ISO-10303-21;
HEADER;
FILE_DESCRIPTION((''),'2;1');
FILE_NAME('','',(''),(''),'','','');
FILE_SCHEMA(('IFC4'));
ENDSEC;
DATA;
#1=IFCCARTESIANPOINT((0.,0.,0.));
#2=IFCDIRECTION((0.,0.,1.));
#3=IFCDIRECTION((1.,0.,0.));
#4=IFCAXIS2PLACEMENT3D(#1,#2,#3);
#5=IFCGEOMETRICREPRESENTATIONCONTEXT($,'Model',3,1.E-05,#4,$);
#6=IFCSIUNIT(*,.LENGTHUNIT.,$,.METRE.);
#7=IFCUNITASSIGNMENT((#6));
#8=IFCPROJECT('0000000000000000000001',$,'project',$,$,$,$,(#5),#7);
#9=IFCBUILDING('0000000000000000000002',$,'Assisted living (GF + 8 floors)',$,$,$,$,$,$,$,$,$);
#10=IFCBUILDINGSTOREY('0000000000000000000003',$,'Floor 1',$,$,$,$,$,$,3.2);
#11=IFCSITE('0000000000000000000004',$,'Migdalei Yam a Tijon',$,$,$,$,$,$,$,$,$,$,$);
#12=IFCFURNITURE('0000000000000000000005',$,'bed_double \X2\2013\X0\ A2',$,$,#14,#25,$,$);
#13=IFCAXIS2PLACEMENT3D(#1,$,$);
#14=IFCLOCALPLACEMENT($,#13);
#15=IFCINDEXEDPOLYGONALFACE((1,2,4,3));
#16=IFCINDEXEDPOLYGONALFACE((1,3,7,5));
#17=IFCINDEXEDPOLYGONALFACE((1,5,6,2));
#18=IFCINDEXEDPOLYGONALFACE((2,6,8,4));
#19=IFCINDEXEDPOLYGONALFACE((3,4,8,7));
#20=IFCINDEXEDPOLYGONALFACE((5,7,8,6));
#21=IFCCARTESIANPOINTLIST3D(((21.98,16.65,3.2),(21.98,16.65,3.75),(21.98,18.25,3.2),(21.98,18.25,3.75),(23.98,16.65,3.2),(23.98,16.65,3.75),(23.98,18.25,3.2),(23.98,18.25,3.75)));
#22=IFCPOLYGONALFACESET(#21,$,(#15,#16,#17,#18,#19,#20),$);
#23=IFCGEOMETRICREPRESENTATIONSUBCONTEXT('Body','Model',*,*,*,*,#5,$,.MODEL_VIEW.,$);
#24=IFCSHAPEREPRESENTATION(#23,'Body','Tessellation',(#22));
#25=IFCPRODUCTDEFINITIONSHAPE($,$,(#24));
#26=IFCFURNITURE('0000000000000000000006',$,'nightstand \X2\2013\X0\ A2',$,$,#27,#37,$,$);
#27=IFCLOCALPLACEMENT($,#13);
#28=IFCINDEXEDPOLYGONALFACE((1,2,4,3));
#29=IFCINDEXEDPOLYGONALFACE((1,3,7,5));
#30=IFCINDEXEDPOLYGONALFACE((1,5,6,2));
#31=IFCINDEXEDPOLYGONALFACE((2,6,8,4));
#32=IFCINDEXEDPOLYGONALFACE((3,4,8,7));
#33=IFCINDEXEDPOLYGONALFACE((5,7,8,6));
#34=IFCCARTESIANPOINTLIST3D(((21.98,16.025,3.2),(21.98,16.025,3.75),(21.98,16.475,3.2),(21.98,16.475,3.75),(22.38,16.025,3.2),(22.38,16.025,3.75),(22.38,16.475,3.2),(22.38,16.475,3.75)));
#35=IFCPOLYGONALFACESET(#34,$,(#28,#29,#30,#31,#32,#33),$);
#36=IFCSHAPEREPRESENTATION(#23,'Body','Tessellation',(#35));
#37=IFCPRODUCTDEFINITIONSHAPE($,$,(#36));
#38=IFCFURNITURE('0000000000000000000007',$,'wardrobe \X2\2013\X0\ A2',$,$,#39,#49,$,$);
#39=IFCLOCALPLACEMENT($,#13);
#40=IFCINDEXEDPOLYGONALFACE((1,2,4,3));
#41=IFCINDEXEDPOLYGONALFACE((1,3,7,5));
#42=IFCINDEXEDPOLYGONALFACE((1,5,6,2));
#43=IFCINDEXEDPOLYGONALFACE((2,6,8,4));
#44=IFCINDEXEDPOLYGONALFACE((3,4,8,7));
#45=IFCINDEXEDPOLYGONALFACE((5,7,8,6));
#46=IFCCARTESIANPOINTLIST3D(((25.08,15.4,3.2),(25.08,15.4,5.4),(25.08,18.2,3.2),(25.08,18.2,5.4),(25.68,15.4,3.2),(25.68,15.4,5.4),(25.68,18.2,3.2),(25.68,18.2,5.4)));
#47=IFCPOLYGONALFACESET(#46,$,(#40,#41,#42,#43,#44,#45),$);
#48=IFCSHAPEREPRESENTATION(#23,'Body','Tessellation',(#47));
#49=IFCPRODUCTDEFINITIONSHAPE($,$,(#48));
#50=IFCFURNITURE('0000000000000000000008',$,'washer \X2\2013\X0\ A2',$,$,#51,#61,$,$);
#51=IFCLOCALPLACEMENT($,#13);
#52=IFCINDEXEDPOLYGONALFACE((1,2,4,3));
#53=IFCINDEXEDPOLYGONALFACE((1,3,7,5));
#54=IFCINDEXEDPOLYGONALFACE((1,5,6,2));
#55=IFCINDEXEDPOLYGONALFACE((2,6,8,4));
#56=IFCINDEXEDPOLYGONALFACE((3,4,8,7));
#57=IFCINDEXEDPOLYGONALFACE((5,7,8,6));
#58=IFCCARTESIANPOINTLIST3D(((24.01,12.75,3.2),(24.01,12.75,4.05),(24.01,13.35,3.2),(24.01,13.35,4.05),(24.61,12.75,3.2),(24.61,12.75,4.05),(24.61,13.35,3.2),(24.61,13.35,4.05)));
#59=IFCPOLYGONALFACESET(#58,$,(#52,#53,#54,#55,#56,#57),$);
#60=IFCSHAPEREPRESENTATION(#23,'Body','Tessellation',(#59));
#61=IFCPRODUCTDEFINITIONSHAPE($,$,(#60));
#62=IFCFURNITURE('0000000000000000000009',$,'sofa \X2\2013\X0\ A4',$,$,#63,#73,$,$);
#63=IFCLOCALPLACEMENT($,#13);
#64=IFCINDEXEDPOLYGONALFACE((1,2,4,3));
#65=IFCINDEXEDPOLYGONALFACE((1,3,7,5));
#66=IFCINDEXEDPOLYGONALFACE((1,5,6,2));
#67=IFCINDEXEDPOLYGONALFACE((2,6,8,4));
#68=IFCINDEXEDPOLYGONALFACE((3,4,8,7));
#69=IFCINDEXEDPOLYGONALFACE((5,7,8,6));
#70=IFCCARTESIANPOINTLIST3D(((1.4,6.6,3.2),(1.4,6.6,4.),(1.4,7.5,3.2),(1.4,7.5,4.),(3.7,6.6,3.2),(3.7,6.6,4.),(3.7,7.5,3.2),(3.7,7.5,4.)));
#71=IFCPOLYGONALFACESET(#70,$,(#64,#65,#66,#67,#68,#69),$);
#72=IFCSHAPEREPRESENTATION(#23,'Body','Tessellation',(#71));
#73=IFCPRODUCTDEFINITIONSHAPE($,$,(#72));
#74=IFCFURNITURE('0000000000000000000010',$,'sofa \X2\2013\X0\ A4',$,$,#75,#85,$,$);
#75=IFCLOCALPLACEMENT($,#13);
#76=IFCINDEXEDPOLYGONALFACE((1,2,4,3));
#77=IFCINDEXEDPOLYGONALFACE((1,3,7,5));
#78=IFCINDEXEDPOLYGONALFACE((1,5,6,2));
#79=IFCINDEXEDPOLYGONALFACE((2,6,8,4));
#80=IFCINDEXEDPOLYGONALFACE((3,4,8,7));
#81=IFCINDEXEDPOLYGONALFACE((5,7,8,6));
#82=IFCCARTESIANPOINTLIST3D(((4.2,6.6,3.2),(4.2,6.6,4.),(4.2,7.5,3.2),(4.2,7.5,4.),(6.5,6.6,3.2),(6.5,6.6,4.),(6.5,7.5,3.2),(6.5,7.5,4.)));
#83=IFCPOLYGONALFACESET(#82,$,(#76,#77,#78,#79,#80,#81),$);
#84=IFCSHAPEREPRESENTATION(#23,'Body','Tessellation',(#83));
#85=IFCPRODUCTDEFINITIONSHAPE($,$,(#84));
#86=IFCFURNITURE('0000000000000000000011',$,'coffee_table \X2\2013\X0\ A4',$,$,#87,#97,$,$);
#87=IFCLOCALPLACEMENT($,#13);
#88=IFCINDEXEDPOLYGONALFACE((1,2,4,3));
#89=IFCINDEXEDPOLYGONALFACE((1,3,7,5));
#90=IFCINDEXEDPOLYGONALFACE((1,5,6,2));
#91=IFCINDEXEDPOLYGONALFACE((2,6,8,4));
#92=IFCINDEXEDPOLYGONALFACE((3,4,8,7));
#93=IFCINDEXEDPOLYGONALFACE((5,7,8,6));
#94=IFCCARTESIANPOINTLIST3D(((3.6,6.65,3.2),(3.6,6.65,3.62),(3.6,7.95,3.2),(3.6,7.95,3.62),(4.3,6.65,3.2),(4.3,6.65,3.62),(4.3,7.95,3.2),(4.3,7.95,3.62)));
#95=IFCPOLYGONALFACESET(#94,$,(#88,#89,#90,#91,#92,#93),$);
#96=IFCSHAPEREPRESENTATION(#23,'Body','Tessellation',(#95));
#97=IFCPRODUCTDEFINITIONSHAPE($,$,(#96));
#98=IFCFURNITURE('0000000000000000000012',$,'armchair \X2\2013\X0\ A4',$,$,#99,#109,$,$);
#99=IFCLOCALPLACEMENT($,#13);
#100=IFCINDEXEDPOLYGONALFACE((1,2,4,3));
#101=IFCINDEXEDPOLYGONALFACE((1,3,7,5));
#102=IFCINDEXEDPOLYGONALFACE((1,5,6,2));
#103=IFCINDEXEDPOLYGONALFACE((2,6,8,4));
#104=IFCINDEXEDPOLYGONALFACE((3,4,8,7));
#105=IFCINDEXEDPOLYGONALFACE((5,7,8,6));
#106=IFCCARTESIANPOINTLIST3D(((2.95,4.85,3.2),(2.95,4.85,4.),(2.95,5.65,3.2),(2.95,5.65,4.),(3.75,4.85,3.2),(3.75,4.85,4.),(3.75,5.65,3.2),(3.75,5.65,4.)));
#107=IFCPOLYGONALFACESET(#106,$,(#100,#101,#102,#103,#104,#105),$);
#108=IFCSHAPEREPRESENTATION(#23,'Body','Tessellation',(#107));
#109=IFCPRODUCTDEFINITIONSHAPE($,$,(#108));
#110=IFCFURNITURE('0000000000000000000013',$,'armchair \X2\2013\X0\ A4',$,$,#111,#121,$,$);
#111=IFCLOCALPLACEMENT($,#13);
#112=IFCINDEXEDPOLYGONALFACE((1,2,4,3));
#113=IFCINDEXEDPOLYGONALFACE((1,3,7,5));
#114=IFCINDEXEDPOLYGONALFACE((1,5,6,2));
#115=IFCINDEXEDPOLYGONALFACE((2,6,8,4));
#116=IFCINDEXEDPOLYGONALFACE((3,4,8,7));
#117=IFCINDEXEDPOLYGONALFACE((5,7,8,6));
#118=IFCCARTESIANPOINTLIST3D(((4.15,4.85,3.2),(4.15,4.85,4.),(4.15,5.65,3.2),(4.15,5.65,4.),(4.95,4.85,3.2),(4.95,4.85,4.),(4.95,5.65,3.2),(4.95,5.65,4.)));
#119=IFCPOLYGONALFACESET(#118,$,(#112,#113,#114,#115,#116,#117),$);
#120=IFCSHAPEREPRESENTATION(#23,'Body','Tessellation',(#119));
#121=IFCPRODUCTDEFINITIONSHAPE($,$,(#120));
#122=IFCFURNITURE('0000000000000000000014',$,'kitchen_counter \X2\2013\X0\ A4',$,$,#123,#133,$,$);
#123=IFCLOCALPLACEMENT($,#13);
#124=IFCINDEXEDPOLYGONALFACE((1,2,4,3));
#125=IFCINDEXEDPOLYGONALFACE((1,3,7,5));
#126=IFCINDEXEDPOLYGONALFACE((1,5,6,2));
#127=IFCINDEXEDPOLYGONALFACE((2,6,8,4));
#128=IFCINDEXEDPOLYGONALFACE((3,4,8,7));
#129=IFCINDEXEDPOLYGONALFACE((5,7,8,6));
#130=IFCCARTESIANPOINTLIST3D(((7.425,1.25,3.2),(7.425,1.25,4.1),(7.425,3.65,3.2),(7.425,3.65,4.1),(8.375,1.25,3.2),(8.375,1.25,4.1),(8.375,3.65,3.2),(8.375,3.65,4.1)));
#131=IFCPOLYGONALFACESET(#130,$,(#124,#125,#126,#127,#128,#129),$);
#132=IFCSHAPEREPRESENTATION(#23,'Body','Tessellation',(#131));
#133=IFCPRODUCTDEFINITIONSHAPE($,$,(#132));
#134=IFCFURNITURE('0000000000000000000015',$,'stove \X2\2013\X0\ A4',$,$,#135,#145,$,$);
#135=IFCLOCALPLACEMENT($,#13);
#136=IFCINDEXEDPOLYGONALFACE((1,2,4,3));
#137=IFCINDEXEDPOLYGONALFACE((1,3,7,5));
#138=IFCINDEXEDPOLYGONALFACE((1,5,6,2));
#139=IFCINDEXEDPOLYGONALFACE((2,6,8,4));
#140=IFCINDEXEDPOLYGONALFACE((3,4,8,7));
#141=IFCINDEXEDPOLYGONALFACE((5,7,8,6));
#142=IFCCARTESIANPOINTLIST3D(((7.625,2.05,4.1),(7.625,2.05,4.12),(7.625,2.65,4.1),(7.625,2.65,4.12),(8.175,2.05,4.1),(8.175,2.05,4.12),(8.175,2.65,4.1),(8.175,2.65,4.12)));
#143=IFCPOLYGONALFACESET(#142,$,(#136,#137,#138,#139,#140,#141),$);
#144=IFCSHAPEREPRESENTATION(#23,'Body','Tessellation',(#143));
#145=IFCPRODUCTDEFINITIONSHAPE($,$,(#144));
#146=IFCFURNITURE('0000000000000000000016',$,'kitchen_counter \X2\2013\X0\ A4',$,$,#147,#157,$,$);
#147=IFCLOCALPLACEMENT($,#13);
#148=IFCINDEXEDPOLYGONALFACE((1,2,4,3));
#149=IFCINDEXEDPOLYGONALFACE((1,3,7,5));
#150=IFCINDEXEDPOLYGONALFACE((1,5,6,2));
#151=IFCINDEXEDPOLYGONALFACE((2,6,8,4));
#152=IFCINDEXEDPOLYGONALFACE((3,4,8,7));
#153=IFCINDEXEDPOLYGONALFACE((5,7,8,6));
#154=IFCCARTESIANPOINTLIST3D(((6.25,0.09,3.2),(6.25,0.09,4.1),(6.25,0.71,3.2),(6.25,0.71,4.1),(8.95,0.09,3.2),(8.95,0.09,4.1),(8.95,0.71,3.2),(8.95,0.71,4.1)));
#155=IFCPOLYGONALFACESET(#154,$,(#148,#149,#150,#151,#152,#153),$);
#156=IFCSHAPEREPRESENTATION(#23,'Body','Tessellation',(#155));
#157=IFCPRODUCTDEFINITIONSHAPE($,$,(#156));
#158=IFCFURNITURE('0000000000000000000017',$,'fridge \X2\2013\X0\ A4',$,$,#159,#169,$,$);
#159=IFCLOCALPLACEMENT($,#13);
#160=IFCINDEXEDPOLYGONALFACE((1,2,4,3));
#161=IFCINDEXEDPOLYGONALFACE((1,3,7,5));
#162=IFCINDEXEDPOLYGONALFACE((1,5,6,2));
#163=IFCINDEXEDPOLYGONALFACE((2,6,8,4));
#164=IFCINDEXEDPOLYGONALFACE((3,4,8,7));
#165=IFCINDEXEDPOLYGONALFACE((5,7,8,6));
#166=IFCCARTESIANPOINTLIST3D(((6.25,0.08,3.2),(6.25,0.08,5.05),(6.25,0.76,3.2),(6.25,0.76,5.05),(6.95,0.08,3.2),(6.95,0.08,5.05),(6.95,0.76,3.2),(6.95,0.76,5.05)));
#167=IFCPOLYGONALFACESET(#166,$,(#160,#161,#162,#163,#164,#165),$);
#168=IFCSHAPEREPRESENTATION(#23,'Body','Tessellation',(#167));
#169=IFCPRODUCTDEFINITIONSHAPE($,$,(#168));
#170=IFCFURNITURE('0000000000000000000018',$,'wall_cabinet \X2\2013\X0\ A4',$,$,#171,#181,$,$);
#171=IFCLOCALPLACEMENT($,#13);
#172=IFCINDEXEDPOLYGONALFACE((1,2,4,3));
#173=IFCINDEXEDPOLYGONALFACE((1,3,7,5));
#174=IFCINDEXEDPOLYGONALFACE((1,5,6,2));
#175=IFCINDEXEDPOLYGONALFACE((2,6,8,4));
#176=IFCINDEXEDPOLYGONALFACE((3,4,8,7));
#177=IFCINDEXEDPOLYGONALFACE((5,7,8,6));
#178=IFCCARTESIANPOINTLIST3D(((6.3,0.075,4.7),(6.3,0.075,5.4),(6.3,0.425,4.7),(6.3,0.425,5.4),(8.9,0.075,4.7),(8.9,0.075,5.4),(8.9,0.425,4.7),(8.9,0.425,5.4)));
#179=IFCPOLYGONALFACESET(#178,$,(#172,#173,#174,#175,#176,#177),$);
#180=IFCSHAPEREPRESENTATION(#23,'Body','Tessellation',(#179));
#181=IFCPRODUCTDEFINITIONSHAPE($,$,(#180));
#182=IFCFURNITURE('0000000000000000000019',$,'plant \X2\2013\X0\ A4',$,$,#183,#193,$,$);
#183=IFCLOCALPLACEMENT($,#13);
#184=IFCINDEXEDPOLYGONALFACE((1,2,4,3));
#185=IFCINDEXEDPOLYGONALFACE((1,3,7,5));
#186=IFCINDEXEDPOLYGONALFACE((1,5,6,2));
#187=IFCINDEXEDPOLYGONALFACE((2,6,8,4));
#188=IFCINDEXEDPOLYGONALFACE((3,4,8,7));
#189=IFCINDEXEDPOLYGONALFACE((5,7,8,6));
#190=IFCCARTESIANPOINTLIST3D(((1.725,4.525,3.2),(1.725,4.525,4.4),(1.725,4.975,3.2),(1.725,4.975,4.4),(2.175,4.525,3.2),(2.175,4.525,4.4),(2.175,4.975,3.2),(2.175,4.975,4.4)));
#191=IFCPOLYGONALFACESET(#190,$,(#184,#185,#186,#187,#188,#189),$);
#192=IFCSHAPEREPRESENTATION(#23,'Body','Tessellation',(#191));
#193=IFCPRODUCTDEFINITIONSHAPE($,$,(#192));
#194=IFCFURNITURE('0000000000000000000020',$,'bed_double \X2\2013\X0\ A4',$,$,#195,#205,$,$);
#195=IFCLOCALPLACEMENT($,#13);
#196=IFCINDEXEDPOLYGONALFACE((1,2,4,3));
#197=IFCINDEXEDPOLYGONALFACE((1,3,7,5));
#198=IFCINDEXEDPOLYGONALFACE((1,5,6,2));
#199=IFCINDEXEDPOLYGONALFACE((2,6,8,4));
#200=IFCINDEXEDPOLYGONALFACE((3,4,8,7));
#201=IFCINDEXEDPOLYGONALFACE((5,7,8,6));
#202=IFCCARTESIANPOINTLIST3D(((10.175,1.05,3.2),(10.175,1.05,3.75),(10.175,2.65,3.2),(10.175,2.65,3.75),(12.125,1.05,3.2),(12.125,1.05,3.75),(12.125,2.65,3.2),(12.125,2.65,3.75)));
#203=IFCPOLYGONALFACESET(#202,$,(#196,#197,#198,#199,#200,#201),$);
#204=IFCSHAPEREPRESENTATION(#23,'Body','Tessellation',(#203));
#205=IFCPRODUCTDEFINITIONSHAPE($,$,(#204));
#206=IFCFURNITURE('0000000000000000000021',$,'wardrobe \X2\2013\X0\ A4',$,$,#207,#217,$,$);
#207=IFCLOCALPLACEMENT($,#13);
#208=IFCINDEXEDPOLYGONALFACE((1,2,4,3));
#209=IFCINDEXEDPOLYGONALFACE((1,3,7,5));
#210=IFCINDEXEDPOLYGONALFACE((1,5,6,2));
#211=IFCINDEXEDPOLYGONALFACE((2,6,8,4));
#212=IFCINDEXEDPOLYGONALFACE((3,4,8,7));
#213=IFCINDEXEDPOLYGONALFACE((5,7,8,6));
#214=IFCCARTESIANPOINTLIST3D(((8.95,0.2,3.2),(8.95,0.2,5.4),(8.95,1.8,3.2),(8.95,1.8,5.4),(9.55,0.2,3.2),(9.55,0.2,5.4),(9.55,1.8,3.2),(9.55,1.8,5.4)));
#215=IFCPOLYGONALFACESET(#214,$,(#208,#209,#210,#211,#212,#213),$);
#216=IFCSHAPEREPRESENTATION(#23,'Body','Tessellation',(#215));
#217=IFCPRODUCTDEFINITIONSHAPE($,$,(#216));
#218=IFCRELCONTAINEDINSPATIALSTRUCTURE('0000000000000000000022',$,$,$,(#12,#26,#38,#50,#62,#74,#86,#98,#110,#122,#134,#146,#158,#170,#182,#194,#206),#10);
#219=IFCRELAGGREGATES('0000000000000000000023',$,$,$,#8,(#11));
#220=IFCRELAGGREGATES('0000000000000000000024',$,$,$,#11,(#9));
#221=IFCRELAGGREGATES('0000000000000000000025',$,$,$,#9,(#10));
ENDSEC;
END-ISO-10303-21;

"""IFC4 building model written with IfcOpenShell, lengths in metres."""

from ifc_helpers import new_model, si_unit, frame, origin_with_axes, context, subcontext, project, spatial, line, indexed_curve, outline, extrude, element, save


model = new_model("IFC4")

# Units and contexts
model_context = context("Model", 3, precision=1e-05, world=origin_with_axes())
body_context = subcontext(model_context, "Body", "Model", "MODEL_VIEW")
ifc_project = project(units=[si_unit("LENGTHUNIT", "METRE")], contexts=[model_context])

# Site, building, storey
site = spatial("IfcSite", under=ifc_project, Name="Migdalei Yam a Tijon")
building = spatial("IfcBuilding", under=site, Name="Assisted living (GF + 8 floors)")
storey = spatial("IfcBuildingStorey", under=building, Name="Floor 1", Elevation=3.2)

# Furniture
element("IfcFurniture", 1, inside=storey, Name="bed_double – A2", context=body_context, shape_type="SweptSolid", body=[
    extrude(outline(indexed_curve([(0.0, 0.0), (2.0, 0.0), (2.0, 1.6), (0.0, 1.6)], segments=[line(1, 2, 3, 4, 1)])), frame((21.98, 16.65, 3.2), z_axis=(0.0, 0.0, 1.0), x_axis=(1.0, 0.0, 0.0)), (0.0, 0.0, 1.0), 0.55),
])
element("IfcFurniture", 2, inside=storey, Name="nightstand – A2", context=body_context, shape_type="SweptSolid", body=[
    extrude(outline(indexed_curve([(0.0, 0.0), (0.4, 0.0), (0.4, 0.45), (0.0, 0.45)], segments=[line(1, 2, 3, 4, 1)])), frame((21.98, 16.025, 3.2), z_axis=(0.0, 0.0, 1.0), x_axis=(1.0, 0.0, 0.0)), (0.0, 0.0, 1.0), 0.55),
])
element("IfcFurniture", 3, inside=storey, Name="wardrobe – A2", context=body_context, shape_type="SweptSolid", body=[
    extrude(outline(indexed_curve([(0.0, 0.0), (0.6, 0.0), (0.6, 2.8), (0.0, 2.8)], segments=[line(1, 2, 3, 4, 1)])), frame((25.08, 15.4, 3.2), z_axis=(0.0, 0.0, 1.0), x_axis=(1.0, 0.0, 0.0)), (0.0, 0.0, 1.0), 2.2),
])
element("IfcFurniture", 4, inside=storey, Name="washer – A2", context=body_context, shape_type="SweptSolid", body=[
    extrude(outline(indexed_curve([(0.0, 0.0), (0.6, 0.0), (0.6, 0.6), (0.0, 0.6)], segments=[line(1, 2, 3, 4, 1)])), frame((24.01, 12.75, 3.2), z_axis=(0.0, 0.0, 1.0), x_axis=(1.0, 0.0, 0.0)), (0.0, 0.0, 1.0), 0.85),
])
element("IfcFurniture", 5, inside=storey, Name="sofa – A4", context=body_context, shape_type="SweptSolid", body=[
    extrude(outline(indexed_curve([(0.0, 0.0), (2.3, 0.0), (2.3, 0.9), (0.0, 0.9)], segments=[line(1, 2, 3, 4, 1)])), frame((1.4, 6.6, 3.2), z_axis=(0.0, 0.0, 1.0), x_axis=(1.0, 0.0, 0.0)), (0.0, 0.0, 1.0), 0.8),
])
element("IfcFurniture", 6, inside=storey, Name="sofa – A4", context=body_context, shape_type="SweptSolid", body=[
    extrude(outline(indexed_curve([(0.0, 0.0), (2.3, 0.0), (2.3, 0.9), (0.0, 0.9)], segments=[line(1, 2, 3, 4, 1)])), frame((4.2, 6.6, 3.2), z_axis=(0.0, 0.0, 1.0), x_axis=(1.0, 0.0, 0.0)), (0.0, 0.0, 1.0), 0.8),
])
element("IfcFurniture", 7, inside=storey, Name="coffee_table – A4", context=body_context, shape_type="SweptSolid", body=[
    extrude(outline(indexed_curve([(0.0, 0.0), (0.7, 0.0), (0.7, 1.3), (0.0, 1.3)], segments=[line(1, 2, 3, 4, 1)])), frame((3.6, 6.65, 3.2), z_axis=(0.0, 0.0, 1.0), x_axis=(1.0, 0.0, 0.0)), (0.0, 0.0, 1.0), 0.42),
])
element("IfcFurniture", 8, inside=storey, Name="armchair – A4", context=body_context, shape_type="SweptSolid", body=[
    extrude(outline(indexed_curve([(0.0, 0.0), (0.8, 0.0), (0.8, 0.8), (0.0, 0.8)], segments=[line(1, 2, 3, 4, 1)])), frame((2.95, 4.85, 3.2), z_axis=(0.0, 0.0, 1.0), x_axis=(1.0, 0.0, 0.0)), (0.0, 0.0, 1.0), 0.8),
])
element("IfcFurniture", 9, inside=storey, Name="armchair – A4", context=body_context, shape_type="SweptSolid", body=[
    extrude(outline(indexed_curve([(0.0, 0.0), (0.8, 0.0), (0.8, 0.8), (0.0, 0.8)], segments=[line(1, 2, 3, 4, 1)])), frame((4.15, 4.85, 3.2), z_axis=(0.0, 0.0, 1.0), x_axis=(1.0, 0.0, 0.0)), (0.0, 0.0, 1.0), 0.8),
])
element("IfcFurniture", 10, inside=storey, Name="kitchen_counter – A4", context=body_context, shape_type="SweptSolid", body=[
    extrude(outline(indexed_curve([(0.0, 0.0), (0.95, 0.0), (0.95, 2.4), (0.0, 2.4)], segments=[line(1, 2, 3, 4, 1)])), frame((7.425, 1.25, 3.2), z_axis=(0.0, 0.0, 1.0), x_axis=(1.0, 0.0, 0.0)), (0.0, 0.0, 1.0), 0.9),
])
element("IfcFurniture", 11, inside=storey, Name="stove – A4", context=body_context, shape_type="SweptSolid", body=[
    extrude(outline(indexed_curve([(0.0, 0.0), (0.55, 0.0), (0.55, 0.6), (0.0, 0.6)], segments=[line(1, 2, 3, 4, 1)])), frame((7.625, 2.05, 4.1), z_axis=(0.0, 0.0, 1.0), x_axis=(1.0, 0.0, 0.0)), (0.0, 0.0, 1.0), 0.02),
])
element("IfcFurniture", 12, inside=storey, Name="kitchen_counter – A4", context=body_context, shape_type="SweptSolid", body=[
    extrude(outline(indexed_curve([(0.0, 0.0), (2.7, 0.0), (2.7, 0.62), (0.0, 0.62)], segments=[line(1, 2, 3, 4, 1)])), frame((6.25, 0.09, 3.2), z_axis=(0.0, 0.0, 1.0), x_axis=(1.0, 0.0, 0.0)), (0.0, 0.0, 1.0), 0.9),
])
element("IfcFurniture", 13, inside=storey, Name="fridge – A4", context=body_context, shape_type="SweptSolid", body=[
    extrude(outline(indexed_curve([(0.0, 0.0), (0.7, 0.0), (0.7, 0.68), (0.0, 0.68)], segments=[line(1, 2, 3, 4, 1)])), frame((6.25, 0.08, 3.2), z_axis=(0.0, 0.0, 1.0), x_axis=(1.0, 0.0, 0.0)), (0.0, 0.0, 1.0), 1.85),
])
element("IfcFurniture", 14, inside=storey, Name="wall_cabinet – A4", context=body_context, shape_type="SweptSolid", body=[
    extrude(outline(indexed_curve([(0.0, 0.0), (2.6, 0.0), (2.6, 0.35), (0.0, 0.35)], segments=[line(1, 2, 3, 4, 1)])), frame((6.3, 0.075, 4.7), z_axis=(0.0, 0.0, 1.0), x_axis=(1.0, 0.0, 0.0)), (0.0, 0.0, 1.0), 0.7),
])
element("IfcFurniture", 15, inside=storey, Name="plant – A4", context=body_context, shape_type="SweptSolid", body=[
    extrude(outline(indexed_curve([(0.0, 0.0), (0.45, 0.0), (0.45, 0.45), (0.0, 0.45)], segments=[line(1, 2, 3, 4, 1)])), frame((1.725, 4.525, 3.2), z_axis=(0.0, 0.0, 1.0), x_axis=(1.0, 0.0, 0.0)), (0.0, 0.0, 1.0), 1.2),
])
element("IfcFurniture", 16, inside=storey, Name="bed_double – A4", context=body_context, shape_type="SweptSolid", body=[
    extrude(outline(indexed_curve([(0.0, 0.0), (1.95, 0.0), (1.95, 1.6), (0.0, 1.6)], segments=[line(1, 2, 3, 4, 1)])), frame((10.175, 1.05, 3.2), z_axis=(0.0, 0.0, 1.0), x_axis=(1.0, 0.0, 0.0)), (0.0, 0.0, 1.0), 0.55),
])
element("IfcFurniture", 17, inside=storey, Name="wardrobe – A4", context=body_context, shape_type="SweptSolid", body=[
    extrude(outline(indexed_curve([(0.0, 0.0), (0.6, 0.0), (0.6, 1.6), (0.0, 1.6)], segments=[line(1, 2, 3, 4, 1)])), frame((8.95, 0.2, 3.2), z_axis=(0.0, 0.0, 1.0), x_axis=(1.0, 0.0, 0.0)), (0.0, 0.0, 1.0), 2.2),
])

save(model, "model.ifc")
